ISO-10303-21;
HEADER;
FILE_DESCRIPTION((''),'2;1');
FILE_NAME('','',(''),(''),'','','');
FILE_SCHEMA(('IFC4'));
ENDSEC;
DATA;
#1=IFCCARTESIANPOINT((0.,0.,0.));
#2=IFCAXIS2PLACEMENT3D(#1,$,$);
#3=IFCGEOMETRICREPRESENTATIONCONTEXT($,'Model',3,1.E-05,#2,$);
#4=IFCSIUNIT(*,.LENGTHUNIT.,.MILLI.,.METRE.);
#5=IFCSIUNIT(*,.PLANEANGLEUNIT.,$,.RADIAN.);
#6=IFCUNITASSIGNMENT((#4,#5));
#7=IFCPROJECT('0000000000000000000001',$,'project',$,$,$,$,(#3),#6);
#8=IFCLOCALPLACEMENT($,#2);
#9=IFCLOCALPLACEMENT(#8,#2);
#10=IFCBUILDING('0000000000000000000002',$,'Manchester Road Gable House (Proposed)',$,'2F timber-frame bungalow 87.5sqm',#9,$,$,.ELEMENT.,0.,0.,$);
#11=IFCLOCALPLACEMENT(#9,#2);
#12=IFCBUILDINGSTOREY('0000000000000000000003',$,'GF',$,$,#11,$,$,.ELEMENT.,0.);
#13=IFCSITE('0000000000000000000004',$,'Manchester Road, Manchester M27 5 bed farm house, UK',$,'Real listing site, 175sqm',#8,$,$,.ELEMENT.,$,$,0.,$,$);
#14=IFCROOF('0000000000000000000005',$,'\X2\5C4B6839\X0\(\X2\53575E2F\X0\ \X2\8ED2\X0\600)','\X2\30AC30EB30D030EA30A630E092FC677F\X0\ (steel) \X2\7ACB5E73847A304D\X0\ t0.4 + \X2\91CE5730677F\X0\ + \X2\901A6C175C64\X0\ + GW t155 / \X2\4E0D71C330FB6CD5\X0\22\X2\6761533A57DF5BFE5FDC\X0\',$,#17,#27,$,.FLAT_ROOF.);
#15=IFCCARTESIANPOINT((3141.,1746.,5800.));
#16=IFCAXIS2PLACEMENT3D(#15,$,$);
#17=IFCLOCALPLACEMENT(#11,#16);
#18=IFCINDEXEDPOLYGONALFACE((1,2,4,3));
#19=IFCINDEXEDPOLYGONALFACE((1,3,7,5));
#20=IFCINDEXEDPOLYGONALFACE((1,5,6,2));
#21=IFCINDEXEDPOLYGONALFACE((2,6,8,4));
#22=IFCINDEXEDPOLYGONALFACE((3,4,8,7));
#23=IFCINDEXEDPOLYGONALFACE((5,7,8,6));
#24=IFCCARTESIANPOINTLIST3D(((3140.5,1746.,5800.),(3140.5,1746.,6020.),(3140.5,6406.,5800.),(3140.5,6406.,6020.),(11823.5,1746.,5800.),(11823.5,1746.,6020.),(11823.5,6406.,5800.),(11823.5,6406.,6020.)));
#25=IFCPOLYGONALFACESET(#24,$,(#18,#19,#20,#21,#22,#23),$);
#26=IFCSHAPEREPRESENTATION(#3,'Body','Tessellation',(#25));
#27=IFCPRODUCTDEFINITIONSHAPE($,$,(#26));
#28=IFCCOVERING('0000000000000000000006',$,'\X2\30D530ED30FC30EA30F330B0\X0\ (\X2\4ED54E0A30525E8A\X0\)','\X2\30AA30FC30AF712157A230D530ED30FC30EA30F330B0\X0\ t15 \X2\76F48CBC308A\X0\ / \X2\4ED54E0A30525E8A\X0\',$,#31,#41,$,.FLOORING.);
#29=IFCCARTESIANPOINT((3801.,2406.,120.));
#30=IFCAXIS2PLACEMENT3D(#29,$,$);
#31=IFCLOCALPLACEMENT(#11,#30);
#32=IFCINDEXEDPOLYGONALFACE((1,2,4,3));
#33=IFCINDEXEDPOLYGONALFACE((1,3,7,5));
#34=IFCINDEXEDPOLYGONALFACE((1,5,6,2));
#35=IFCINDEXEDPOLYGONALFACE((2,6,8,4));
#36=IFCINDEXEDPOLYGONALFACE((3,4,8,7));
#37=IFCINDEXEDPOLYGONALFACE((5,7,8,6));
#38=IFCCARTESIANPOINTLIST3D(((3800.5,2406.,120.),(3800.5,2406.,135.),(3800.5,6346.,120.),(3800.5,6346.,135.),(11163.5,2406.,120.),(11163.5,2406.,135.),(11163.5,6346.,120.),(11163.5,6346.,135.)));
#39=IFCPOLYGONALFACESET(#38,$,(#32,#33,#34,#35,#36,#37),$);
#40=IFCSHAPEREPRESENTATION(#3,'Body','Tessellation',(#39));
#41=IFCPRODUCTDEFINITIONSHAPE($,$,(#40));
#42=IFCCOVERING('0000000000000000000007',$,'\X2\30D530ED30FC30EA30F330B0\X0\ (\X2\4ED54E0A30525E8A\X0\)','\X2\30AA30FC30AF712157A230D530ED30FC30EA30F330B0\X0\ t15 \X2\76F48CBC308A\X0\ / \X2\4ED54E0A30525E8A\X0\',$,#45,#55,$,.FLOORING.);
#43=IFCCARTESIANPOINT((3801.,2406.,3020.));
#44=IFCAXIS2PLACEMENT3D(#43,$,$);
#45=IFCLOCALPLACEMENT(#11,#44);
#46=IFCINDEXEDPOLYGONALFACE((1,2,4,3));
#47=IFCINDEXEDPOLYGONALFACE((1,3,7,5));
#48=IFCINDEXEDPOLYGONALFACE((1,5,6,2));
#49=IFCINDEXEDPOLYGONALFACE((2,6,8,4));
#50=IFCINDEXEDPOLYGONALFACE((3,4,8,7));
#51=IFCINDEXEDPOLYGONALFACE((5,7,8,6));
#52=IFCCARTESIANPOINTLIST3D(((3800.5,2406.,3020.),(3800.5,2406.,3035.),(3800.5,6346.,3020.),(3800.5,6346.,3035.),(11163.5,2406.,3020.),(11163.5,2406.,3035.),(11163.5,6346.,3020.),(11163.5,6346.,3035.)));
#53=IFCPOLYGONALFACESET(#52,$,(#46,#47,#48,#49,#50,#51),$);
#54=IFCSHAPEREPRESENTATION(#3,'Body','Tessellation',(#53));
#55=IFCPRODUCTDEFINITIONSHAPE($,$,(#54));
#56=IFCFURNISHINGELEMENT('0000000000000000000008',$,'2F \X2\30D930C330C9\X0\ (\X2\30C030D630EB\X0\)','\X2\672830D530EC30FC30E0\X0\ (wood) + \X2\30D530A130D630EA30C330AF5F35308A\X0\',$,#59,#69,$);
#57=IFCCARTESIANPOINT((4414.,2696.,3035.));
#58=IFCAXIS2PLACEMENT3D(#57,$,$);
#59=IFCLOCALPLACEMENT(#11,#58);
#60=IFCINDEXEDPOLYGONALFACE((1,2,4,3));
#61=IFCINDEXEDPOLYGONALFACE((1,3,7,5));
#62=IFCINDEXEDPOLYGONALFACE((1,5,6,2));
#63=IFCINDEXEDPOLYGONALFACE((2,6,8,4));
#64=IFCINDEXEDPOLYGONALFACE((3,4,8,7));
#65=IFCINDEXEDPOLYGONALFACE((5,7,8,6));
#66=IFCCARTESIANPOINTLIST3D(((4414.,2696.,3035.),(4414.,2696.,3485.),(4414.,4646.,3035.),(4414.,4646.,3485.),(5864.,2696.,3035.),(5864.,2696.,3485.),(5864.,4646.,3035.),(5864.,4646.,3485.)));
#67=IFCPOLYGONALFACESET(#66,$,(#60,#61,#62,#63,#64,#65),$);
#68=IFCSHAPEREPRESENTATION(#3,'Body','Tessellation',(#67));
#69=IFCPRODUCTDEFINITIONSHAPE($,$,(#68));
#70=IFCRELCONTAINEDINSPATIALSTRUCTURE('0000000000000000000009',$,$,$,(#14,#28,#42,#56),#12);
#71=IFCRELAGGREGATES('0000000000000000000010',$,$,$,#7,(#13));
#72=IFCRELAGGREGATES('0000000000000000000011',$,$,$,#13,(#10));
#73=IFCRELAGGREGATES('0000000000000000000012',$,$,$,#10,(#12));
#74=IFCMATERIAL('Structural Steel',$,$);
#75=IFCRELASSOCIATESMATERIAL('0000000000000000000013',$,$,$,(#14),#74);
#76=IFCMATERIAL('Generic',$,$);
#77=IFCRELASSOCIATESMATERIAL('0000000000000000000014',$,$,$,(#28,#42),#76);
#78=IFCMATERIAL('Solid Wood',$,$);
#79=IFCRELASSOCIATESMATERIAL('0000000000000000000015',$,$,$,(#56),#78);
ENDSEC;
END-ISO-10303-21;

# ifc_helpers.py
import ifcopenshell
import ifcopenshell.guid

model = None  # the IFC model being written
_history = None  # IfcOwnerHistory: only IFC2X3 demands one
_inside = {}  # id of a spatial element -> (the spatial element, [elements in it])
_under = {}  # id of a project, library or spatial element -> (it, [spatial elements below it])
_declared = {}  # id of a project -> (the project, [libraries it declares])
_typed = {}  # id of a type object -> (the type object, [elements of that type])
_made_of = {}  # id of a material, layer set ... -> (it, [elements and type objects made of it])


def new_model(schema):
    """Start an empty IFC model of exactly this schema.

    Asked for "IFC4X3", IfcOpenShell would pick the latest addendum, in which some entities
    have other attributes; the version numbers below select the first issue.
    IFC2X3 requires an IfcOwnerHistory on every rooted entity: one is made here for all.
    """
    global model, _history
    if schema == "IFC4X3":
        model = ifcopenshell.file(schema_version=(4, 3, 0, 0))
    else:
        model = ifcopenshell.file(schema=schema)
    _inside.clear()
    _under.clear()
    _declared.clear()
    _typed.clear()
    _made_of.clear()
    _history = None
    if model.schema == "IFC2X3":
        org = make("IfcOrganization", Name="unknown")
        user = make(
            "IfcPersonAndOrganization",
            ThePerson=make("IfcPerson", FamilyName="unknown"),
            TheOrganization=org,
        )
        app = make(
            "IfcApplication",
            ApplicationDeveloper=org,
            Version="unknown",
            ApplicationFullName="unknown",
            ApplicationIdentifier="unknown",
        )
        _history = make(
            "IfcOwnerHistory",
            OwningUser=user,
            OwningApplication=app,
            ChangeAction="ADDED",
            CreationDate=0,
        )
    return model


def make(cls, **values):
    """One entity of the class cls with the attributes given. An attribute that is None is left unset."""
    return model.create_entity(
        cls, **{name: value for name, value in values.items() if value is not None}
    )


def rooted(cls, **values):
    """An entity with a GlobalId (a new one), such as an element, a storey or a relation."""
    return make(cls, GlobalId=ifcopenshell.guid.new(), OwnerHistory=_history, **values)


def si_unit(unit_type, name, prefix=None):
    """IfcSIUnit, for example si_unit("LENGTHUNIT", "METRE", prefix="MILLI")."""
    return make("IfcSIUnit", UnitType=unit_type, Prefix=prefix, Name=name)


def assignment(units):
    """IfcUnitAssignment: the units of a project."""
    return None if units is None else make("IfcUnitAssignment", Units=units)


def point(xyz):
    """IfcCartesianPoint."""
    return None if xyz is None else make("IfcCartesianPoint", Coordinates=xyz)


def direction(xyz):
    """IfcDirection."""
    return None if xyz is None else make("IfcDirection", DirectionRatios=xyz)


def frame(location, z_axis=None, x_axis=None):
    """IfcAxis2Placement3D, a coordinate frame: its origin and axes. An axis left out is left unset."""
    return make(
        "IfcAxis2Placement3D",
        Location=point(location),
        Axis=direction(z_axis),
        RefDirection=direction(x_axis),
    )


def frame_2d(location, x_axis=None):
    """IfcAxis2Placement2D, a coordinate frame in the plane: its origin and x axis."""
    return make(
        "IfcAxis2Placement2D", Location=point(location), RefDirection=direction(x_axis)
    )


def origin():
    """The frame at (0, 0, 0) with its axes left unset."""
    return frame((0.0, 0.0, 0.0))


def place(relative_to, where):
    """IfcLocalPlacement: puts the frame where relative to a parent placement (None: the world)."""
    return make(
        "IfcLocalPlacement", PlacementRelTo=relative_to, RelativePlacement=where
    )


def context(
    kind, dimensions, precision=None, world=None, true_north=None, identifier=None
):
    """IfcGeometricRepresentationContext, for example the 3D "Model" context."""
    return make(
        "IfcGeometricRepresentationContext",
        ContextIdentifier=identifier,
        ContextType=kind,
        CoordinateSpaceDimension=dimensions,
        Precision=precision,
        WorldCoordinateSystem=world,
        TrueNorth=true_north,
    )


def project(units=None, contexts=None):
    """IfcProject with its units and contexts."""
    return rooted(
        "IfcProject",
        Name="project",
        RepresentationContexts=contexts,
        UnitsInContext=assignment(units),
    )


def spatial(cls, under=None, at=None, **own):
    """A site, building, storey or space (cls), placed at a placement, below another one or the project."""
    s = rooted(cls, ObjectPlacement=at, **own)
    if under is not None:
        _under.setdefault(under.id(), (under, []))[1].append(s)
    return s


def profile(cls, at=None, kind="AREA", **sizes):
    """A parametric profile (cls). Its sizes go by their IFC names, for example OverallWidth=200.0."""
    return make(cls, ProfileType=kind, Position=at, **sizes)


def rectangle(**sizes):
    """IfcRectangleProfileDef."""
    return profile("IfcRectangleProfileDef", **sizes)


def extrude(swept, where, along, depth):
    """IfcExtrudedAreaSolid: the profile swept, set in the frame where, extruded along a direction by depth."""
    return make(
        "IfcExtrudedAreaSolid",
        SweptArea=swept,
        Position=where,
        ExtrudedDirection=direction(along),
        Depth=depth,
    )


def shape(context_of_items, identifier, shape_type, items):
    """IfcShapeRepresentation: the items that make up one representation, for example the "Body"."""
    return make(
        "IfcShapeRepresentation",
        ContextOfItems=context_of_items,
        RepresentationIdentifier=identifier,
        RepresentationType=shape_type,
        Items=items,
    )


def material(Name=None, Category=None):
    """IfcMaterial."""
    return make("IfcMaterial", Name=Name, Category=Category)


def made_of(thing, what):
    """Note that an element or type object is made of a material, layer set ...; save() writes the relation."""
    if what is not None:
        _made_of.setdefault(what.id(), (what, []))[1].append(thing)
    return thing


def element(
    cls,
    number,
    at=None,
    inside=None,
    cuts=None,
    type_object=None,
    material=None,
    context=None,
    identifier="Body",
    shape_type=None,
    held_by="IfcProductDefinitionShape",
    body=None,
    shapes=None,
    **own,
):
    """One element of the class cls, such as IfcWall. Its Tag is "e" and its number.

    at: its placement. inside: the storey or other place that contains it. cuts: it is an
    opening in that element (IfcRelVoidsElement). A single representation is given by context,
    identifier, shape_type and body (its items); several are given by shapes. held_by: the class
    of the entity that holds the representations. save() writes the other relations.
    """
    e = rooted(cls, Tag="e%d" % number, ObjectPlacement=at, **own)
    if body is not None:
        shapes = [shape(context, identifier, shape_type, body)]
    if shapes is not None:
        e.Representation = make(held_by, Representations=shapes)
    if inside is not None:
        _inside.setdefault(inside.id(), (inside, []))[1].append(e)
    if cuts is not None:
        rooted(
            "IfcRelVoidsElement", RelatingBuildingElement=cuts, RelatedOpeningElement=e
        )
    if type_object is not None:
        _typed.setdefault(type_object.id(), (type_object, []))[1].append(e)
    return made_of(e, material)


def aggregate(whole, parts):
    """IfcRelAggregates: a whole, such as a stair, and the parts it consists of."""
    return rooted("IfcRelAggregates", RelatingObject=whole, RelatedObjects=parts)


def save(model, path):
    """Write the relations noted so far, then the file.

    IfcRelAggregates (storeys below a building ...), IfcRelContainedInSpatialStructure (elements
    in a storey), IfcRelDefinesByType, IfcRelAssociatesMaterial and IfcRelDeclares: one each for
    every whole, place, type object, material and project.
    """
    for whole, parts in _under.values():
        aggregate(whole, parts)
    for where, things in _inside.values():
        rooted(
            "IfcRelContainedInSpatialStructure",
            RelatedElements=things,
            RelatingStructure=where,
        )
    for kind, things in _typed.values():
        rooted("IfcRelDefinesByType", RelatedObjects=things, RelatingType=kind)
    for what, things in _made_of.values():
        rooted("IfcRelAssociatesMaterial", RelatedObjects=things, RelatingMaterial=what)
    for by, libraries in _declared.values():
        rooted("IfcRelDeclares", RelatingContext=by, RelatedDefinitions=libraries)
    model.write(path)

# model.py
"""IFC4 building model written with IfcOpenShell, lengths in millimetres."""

from ifc_helpers import new_model, si_unit, frame, frame_2d, origin, place, context, project, spatial, rectangle, extrude, material, element, save


model = new_model("IFC4")

# Units and contexts
model_context = context("Model", 3, precision=1e-05, world=origin())
ifc_project = project(units=[si_unit("LENGTHUNIT", "METRE", prefix="MILLI"), si_unit("PLANEANGLEUNIT", "RADIAN")], contexts=[model_context])

# Site, building, storey
site_placement = place(None, origin())
site = spatial("IfcSite", under=ifc_project, at=site_placement, Name="Manchester Road, Manchester M27 5 bed farm house, UK", ObjectType="Real listing site, 175sqm", CompositionType="ELEMENT", RefElevation=0.0)
building_placement = place(site_placement, origin())
building = spatial("IfcBuilding", under=site, at=building_placement, Name="Manchester Road Gable House (Proposed)", ObjectType="2F timber-frame bungalow 87.5sqm", CompositionType="ELEMENT", ElevationOfRefHeight=0.0, ElevationOfTerrain=0.0)
storey_placement = place(building_placement, origin())
storey = spatial("IfcBuildingStorey", under=building, at=storey_placement, Name="GF", CompositionType="ELEMENT", Elevation=0.0)

# Shared definitions
ifc_material_1 = material(Name="Solid Wood")

# Roof
ifc_material_2 = material(Name="Structural Steel")
for number, where, name in (
    (1, (3141.0, 1746.0, 5800.0), "屋根(南帯 軒600)"),
):
    element("IfcRoof", number, at=place(storey_placement, frame(where)), inside=storey, material=ifc_material_2, Name=name, Description="ガルバリウム鋼板 (steel) 立平葺き t0.4 + 野地板 + 通気層 + GW t155 / 不燃・法22条区域対応", PredefinedType="FLAT_ROOF", context=model_context, shape_type="SweptSolid", body=[
        extrude(rectangle(XDim=8683.0, YDim=4660.0, at=frame_2d((4341.0, 2330.0))), frame((3141.0, 1746.0, 5800.0)), (0.0, 0.0, 1.0), 220.0),
    ])

# Coverings
ifc_material_3 = material(Name="Generic")
covering_1_placement = place(storey_placement, frame((3801.0, 2406.0, 120.0)))
element("IfcCovering", 2, at=covering_1_placement, inside=storey, material=ifc_material_3, Name="フローリング (仕上げ床)", Description="オーク無垢フローリング t15 直貼り / 仕上げ床", PredefinedType="FLOORING", context=model_context, shape_type="SweptSolid", body=[
    extrude(rectangle(XDim=7363.0, YDim=3940.0, at=frame_2d((3681.0, 1970.0))), frame((3801.0, 2406.0, 120.0)), (0.0, 0.0, 1.0), 15.0),
])
covering_2_placement = place(storey_placement, frame((3801.0, 2406.0, 3020.0)))
element("IfcCovering", 3, at=covering_2_placement, inside=storey, material=ifc_material_3, Name="フローリング (仕上げ床)", Description="オーク無垢フローリング t15 直貼り / 仕上げ床", PredefinedType="FLOORING", context=model_context, shape_type="SweptSolid", body=[
    extrude(rectangle(XDim=7363.0, YDim=3940.0, at=frame_2d((3681.0, 1970.0))), frame((3801.0, 2406.0, 3020.0)), (0.0, 0.0, 1.0), 15.0),
])

# Furnishing element
furnishing_placement = place(storey_placement, frame((4414.0, 2696.0, 3035.0)))
element("IfcFurnishingElement", 4, at=furnishing_placement, inside=storey, material=ifc_material_1, Name="2F ベッド (ダブル)", Description="木フレーム (wood) + ファブリック張り", context=model_context, shape_type="SweptSolid", body=[
    extrude(rectangle(XDim=1450.0, YDim=1950.0, at=frame_2d((725.0, 975.0))), frame((4414.0, 2696.0, 3035.0)), (0.0, 0.0, 1.0), 450.0),
])

save(model, "model.ifc")
